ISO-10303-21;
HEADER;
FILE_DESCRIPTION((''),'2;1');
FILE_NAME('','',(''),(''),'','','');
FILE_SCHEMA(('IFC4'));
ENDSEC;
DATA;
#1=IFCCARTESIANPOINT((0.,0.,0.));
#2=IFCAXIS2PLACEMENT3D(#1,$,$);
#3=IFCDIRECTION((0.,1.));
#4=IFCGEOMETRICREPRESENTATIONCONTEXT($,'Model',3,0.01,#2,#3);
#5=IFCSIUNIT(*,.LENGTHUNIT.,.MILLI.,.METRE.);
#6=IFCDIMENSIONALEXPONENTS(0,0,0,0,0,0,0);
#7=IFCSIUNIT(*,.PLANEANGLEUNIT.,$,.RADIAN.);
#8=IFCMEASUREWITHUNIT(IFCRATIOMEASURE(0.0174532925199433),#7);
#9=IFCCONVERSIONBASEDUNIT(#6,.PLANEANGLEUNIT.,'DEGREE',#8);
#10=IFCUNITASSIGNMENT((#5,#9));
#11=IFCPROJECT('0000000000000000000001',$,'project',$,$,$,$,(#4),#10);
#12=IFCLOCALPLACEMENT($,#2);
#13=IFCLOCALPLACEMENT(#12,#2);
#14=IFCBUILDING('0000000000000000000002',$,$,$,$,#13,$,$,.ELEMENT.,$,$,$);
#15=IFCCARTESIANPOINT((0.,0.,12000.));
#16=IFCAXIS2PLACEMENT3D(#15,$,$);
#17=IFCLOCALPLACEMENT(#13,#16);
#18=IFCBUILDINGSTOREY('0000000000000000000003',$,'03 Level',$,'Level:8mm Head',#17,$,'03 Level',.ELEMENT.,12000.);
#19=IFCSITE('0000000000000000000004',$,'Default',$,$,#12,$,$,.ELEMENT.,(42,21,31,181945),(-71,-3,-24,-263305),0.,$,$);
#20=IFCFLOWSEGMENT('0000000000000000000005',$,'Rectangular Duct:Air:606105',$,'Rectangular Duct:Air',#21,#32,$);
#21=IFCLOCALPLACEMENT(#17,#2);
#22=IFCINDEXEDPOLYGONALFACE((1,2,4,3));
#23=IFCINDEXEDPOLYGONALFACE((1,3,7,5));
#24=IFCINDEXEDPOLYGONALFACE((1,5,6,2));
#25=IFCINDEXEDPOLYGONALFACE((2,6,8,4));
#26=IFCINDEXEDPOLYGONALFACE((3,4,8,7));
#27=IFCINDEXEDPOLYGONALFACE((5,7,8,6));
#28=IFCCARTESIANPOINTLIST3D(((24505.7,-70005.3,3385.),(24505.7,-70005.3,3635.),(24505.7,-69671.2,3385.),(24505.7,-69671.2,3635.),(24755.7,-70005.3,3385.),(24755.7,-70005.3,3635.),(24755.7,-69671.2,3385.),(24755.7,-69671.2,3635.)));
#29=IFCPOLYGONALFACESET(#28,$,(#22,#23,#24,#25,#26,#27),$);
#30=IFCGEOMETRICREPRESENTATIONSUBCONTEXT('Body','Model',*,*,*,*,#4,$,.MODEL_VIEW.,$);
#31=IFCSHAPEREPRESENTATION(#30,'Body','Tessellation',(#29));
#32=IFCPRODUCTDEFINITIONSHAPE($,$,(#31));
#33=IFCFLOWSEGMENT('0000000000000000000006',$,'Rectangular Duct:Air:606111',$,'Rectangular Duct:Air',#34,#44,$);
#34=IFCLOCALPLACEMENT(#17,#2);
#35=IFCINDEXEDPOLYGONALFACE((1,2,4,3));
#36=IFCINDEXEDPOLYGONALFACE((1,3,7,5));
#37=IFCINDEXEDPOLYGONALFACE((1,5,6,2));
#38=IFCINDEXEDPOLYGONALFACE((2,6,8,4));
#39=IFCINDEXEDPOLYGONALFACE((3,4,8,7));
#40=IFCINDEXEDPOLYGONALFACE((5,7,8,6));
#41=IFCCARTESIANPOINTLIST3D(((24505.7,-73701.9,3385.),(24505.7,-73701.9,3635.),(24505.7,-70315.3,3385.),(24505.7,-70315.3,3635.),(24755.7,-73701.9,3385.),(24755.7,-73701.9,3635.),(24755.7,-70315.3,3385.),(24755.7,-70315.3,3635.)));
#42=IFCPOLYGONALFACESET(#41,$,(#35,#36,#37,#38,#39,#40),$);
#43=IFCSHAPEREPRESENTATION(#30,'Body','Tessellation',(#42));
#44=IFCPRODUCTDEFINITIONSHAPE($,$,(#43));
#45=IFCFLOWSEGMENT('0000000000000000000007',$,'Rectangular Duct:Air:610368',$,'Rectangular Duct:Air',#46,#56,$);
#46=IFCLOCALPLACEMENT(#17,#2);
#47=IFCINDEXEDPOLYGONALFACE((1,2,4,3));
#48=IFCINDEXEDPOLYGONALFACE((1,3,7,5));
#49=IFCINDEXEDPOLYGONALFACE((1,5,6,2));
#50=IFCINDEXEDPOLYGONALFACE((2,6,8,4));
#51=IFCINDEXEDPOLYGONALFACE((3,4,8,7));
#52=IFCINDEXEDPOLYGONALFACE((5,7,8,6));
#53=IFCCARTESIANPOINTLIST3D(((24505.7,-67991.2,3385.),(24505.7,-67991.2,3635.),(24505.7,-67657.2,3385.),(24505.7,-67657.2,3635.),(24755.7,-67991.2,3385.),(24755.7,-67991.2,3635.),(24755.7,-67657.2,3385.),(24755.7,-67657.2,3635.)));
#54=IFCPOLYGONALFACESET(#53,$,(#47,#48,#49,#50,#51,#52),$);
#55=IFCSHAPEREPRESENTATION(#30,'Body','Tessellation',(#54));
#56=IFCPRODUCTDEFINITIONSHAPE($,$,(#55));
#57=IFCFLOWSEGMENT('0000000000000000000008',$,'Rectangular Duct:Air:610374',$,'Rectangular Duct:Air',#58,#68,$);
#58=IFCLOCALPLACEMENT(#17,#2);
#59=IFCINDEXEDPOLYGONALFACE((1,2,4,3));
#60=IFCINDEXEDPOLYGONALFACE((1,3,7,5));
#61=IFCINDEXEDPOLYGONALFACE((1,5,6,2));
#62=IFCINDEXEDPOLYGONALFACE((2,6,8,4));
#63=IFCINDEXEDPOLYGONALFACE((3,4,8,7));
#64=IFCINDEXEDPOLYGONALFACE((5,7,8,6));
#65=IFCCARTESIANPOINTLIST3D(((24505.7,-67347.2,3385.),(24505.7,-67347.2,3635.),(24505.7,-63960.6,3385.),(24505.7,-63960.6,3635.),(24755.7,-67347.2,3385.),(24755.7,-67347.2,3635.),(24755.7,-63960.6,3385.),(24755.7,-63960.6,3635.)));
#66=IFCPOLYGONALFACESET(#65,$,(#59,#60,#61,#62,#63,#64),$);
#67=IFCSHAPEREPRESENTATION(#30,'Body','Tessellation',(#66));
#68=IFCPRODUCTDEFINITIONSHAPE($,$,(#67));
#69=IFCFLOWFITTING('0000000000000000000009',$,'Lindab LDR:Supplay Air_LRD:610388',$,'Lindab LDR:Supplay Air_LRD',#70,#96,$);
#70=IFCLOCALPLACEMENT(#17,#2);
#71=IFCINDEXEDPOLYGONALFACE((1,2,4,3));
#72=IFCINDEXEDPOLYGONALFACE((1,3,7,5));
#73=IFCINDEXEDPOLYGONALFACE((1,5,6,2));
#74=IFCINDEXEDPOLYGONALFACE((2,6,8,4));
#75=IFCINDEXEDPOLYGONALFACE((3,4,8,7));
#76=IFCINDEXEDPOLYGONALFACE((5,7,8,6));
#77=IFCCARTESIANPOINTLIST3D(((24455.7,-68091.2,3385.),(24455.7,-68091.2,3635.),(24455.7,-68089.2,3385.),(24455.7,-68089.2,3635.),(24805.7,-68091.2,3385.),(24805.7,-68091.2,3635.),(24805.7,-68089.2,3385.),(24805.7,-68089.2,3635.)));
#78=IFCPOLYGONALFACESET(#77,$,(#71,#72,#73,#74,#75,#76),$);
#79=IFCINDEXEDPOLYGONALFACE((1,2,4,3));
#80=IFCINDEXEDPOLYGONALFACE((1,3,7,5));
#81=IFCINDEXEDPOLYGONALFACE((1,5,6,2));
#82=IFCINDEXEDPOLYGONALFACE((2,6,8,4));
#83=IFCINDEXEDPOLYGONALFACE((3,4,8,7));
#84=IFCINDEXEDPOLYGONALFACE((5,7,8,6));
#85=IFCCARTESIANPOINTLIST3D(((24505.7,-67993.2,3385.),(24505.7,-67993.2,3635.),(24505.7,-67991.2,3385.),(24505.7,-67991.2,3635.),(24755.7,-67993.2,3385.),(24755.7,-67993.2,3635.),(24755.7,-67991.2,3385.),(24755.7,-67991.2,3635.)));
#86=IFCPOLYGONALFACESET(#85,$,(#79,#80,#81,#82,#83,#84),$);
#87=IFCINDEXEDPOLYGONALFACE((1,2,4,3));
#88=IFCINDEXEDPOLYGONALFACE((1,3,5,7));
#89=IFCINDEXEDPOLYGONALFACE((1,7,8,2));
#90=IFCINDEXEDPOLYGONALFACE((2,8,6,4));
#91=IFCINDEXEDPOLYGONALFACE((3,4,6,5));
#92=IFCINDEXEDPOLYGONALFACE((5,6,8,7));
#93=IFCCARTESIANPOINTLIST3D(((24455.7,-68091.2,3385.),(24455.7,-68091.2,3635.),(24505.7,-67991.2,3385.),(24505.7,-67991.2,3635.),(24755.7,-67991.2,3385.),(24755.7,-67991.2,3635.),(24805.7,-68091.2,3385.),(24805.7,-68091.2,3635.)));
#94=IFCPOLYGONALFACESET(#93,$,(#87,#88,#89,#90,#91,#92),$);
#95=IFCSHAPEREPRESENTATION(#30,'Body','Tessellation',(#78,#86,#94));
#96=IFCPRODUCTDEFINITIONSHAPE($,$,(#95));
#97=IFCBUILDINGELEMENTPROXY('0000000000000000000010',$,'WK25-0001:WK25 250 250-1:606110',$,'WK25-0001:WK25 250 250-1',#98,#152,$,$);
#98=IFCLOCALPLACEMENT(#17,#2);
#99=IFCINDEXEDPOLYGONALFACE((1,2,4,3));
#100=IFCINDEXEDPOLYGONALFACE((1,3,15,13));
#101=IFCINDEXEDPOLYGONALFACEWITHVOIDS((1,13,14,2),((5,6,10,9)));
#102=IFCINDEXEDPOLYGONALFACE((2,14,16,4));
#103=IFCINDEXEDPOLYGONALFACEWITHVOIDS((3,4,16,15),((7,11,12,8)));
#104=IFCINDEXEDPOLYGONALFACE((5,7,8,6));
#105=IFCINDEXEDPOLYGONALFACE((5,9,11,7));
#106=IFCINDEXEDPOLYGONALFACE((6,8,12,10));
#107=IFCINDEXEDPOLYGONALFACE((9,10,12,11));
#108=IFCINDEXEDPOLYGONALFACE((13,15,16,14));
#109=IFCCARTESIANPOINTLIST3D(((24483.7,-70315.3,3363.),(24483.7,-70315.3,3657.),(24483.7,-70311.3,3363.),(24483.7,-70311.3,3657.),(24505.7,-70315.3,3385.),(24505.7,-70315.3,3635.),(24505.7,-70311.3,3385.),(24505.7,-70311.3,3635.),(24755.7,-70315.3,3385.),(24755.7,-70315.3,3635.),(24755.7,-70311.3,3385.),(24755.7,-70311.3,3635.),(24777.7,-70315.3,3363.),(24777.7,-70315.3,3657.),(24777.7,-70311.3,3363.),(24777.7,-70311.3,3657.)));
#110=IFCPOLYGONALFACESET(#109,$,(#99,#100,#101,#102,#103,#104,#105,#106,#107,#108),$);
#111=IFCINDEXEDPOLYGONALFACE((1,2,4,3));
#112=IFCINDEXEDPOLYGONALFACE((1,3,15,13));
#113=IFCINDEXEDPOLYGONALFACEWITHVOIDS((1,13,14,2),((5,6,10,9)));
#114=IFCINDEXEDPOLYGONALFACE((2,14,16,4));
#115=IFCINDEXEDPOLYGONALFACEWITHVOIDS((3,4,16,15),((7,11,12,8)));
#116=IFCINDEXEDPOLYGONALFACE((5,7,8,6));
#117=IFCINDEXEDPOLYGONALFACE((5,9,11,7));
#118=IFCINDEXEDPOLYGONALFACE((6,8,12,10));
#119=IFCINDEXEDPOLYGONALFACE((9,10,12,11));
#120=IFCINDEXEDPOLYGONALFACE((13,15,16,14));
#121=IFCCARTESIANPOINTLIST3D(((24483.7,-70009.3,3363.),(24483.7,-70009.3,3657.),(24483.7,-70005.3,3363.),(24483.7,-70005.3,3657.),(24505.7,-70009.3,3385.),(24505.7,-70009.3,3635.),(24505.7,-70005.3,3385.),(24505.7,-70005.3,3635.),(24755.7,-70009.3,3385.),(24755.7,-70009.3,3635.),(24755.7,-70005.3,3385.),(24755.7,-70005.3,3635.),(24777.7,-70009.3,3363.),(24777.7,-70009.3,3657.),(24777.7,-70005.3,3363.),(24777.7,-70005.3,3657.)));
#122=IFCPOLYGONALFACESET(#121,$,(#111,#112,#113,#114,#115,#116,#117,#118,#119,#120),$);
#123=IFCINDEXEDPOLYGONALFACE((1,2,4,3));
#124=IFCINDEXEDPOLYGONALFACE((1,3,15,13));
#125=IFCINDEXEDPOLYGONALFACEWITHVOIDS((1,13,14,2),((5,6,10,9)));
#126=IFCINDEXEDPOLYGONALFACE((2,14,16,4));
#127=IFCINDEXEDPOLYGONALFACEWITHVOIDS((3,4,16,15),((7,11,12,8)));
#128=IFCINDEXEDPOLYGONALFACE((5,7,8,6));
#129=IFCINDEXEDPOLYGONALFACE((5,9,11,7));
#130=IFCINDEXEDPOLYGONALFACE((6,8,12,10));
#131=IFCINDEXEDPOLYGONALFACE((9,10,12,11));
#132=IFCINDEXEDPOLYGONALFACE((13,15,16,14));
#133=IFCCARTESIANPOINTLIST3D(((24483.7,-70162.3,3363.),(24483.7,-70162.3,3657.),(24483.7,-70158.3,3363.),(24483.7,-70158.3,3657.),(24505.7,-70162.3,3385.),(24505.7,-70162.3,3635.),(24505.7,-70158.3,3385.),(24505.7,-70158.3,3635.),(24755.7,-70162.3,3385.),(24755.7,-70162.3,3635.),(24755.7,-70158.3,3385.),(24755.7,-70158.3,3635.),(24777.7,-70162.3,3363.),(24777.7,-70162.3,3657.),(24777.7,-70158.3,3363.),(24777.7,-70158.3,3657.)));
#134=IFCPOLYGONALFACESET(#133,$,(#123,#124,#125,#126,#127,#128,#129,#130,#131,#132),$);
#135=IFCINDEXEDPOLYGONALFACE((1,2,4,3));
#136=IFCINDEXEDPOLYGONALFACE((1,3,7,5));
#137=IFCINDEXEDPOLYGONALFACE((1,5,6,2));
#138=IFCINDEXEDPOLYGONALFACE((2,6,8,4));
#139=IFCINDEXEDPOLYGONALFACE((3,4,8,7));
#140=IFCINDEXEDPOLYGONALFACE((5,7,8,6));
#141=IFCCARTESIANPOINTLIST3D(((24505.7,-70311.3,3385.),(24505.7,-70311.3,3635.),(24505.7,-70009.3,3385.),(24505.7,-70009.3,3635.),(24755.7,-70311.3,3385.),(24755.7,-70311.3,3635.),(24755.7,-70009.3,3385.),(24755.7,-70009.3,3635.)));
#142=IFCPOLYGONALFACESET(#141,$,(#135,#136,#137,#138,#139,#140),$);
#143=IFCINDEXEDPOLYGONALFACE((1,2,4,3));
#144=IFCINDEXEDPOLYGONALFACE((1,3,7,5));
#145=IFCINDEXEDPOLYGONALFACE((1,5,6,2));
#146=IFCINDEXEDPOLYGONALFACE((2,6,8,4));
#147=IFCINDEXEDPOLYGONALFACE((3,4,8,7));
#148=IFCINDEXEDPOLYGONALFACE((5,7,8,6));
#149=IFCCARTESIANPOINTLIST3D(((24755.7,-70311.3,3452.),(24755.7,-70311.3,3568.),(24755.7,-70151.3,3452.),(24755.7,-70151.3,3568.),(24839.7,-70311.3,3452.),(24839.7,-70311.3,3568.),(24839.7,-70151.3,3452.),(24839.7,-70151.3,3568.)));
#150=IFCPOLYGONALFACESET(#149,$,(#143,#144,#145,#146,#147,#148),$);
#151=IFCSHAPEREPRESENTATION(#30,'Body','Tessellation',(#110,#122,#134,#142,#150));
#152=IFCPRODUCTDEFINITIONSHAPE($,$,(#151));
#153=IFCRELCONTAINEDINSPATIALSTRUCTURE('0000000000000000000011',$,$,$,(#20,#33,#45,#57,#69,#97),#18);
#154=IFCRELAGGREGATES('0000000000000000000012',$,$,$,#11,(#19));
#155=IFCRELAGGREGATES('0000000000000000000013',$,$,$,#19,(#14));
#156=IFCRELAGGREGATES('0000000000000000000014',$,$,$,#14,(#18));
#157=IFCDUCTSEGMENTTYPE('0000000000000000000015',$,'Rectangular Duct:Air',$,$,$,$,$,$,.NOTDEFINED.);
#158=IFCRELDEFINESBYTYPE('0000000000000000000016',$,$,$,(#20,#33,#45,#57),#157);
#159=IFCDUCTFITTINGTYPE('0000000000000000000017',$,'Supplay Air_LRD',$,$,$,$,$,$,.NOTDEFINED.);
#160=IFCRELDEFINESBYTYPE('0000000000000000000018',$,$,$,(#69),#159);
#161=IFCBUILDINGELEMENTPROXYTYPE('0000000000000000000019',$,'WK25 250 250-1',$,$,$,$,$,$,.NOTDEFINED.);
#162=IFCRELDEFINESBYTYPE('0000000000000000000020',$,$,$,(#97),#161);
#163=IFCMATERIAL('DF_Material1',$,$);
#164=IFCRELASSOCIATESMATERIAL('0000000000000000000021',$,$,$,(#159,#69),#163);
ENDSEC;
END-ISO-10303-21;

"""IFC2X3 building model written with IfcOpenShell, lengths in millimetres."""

from ifc_helpers import new_model, entity, si_unit, converted_unit, direction, frame, frame_2d, origin, origin_2d_with_axis, place, context, subcontext, project, spatial, polyline, rectangle, outline, extrude, source, transform, mapped, material, type_object, type_shapes, element, save


model = new_model("IFC2X3")

# Units and contexts
model_context = context("Model", 3, precision=0.01, world=origin(), true_north=direction((0.0, 1.0)))
body_context = subcontext(model_context, "Body", "Model", "MODEL_VIEW")
ifc_project = project(units=[si_unit("LENGTHUNIT", "METRE", prefix="MILLI"), converted_unit("PLANEANGLEUNIT", "DEGREE", entity("IfcRatioMeasure", 0.0174532925199433), si_unit("PLANEANGLEUNIT", "RADIAN"), dimensions=[0, 0, 0, 0, 0, 0, 0])], contexts=[model_context])

# Site, building, storey
site_placement = place(None, origin())
site = spatial("IfcSite", under=ifc_project, at=site_placement, Name="Default", CompositionType="ELEMENT", RefLatitude=(42, 21, 31, 181945), RefLongitude=(-71, -3, -24, -263305), RefElevation=0.0)
building_placement = place(site_placement, origin())
building = spatial("IfcBuilding", under=site, at=building_placement, CompositionType="ELEMENT")
storey_placement = place(building_placement, frame((0.0, 0.0, 12000.0)))
storey = spatial("IfcBuildingStorey", under=building, at=storey_placement, Name="03 Level", ObjectType="Level:8mm Head", LongName="03 Level", CompositionType="ELEMENT", Elevation=12000.0)

# Flow segments
duct_segment_type_1 = type_object("IfcDuctSegmentType", Name="Rectangular Duct:Air", PredefinedType="NOTDEFINED")
flow_segment_1_placement = place(storey_placement, frame((24505.7, -70005.3, 3385.0)))
element("IfcFlowSegment", 1, at=flow_segment_1_placement, inside=storey, type_object=duct_segment_type_1, Name="Rectangular Duct:Air:606105", ObjectType="Rectangular Duct:Air", context=body_context, shape_type="SweptSolid", body=[
    extrude(rectangle(XDim=334.0, YDim=250.0, at=frame_2d((0.0, 0.0), x_axis=(1.0, 0.0))), frame((125.0, 167.0, 0.0), z_axis=(0.0, 0.0, 1.0), x_axis=(0.0, 1.0, 0.0)), (0.0, 0.0, 1.0), 250.0),
])
flow_segment_2_placement = place(storey_placement, frame((24505.7, -73701.9, 3385.0)))
element("IfcFlowSegment", 2, at=flow_segment_2_placement, inside=storey, type_object=duct_segment_type_1, Name="Rectangular Duct:Air:606111", ObjectType="Rectangular Duct:Air", context=body_context, shape_type="SweptSolid", body=[
    extrude(rectangle(XDim=3386.6, YDim=250.0, at=frame_2d((0.0, 0.0), x_axis=(1.0, 0.0))), frame((125.0, 1693.3, 0.0), z_axis=(0.0, 0.0, 1.0), x_axis=(0.0, 1.0, 0.0)), (0.0, 0.0, 1.0), 250.0),
])
flow_segment_3_placement = place(storey_placement, frame((24505.7, -67991.2, 3385.0)))
element("IfcFlowSegment", 3, at=flow_segment_3_placement, inside=storey, type_object=duct_segment_type_1, Name="Rectangular Duct:Air:610368", ObjectType="Rectangular Duct:Air", context=body_context, shape_type="SweptSolid", body=[
    extrude(rectangle(XDim=334.0, YDim=250.0, at=frame_2d((0.0, 0.0), x_axis=(1.0, 0.0))), frame((125.0, 167.0, 0.0), z_axis=(0.0, 0.0, 1.0), x_axis=(0.0, -1.0, 0.0)), (0.0, 0.0, 1.0), 250.0),
])
flow_segment_4_placement = place(storey_placement, frame((24505.7, -67347.2, 3385.0)))
element("IfcFlowSegment", 4, at=flow_segment_4_placement, inside=storey, type_object=duct_segment_type_1, Name="Rectangular Duct:Air:610374", ObjectType="Rectangular Duct:Air", context=body_context, shape_type="SweptSolid", body=[
    extrude(rectangle(XDim=3386.6, YDim=250.0, at=frame_2d((0.0, 0.0), x_axis=(1.0, 0.0))), frame((125.0, 1693.3, 0.0), z_axis=(0.0, 0.0, 1.0), x_axis=(0.0, -1.0, 0.0)), (0.0, 0.0, 1.0), 250.0),
])

# Flow fitting
ifc_material = material(Name="DF_Material1")
duct_fitting_type_1 = type_object("IfcDuctFittingType", Name="Supplay Air_LRD", PredefinedType="NOTDEFINED", material=ifc_material)
shared_shape_1 = source(origin(), body_context, "Body", "SweptSolid", [
    extrude(rectangle(XDim=350.0, YDim=2.0, at=origin_2d_with_axis()), frame((99.0, 0.0, -125.0), z_axis=(0.0, 0.0, 1.0), x_axis=(0.0, 1.0, 0.0)), (0.0, 0.0, 1.0), 250.0),
    extrude(rectangle(XDim=250.0, YDim=2.0, at=origin_2d_with_axis()), frame((1.0, 0.0, -125.0), z_axis=(0.0, 0.0, 1.0), x_axis=(0.0, 1.0, 0.0)), (0.0, 0.0, 1.0), 250.0),
    extrude(outline(polyline([(-125.0, -50.0), (125.0, -50.0), (175.0, 50.0), (-175.0, 50.0), (-125.0, -50.0)])), frame((50.0, 0.0, -125.0), z_axis=(0.0, 0.0, 1.0), x_axis=(0.0, -1.0, 0.0)), (0.0, 0.0, 1.0), 250.0),
])
type_shapes(duct_fitting_type_1, [shared_shape_1])
flow_fitting_1_placement = place(storey_placement, frame((24630.7, -67991.2, 3510.0), z_axis=(0.0, 0.0, 1.0), x_axis=(0.0, -1.0, 0.0)))
element("IfcFlowFitting", 5, at=flow_fitting_1_placement, inside=storey, type_object=duct_fitting_type_1, material=ifc_material, Name="Lindab LDR:Supplay Air_LRD:610388", ObjectType="Lindab LDR:Supplay Air_LRD", context=body_context, shape_type="MappedRepresentation", body=[
    mapped(shared_shape_1, transform((0.0, 0.0, 0.0), scale=1.0)),
])

# Building element proxy
building_element_proxy_type_1 = type_object("IfcBuildingElementProxyType", Name="WK25 250 250-1", PredefinedType="NOTDEFINED")
shared_shape_2 = source(origin(), body_context, "Body", "SweptSolid", [
    extrude(outline(polyline([(-147.0, -147.0), (147.0, -147.0), (147.0, 147.0), (-147.0, 147.0), (-147.0, -147.0)]), holes=[polyline([(-125.0, -125.0), (-125.0, 125.0), (125.0, 125.0), (125.0, -125.0), (-125.0, -125.0)])]), frame((151.0, 0.0, 0.0), z_axis=(1.0, 0.0, 0.0), x_axis=(0.0, 0.0, -1.0)), (0.0, 0.0, 1.0), 4.0),
    extrude(outline(polyline([(-147.0, -147.0), (147.0, -147.0), (147.0, 147.0), (-147.0, 147.0), (-147.0, -147.0)]), holes=[polyline([(-125.0, -125.0), (-125.0, 125.0), (125.0, 125.0), (125.0, -125.0), (-125.0, -125.0)])]), frame((-155.0, 0.0, 0.0), z_axis=(1.0, 0.0, 0.0), x_axis=(0.0, -1.0, 0.0)), (0.0, 0.0, 1.0), 4.0),
    extrude(outline(polyline([(-147.0, -147.0), (147.0, -147.0), (147.0, 147.0), (-147.0, 147.0), (-147.0, -147.0)]), holes=[polyline([(-125.0, -125.0), (-125.0, 125.0), (125.0, 125.0), (125.0, -125.0), (-125.0, -125.0)])]), frame((-2.0, 0.0, 0.0), z_axis=(1.0, 0.0, 0.0), x_axis=(0.0, -1.0, 0.0)), (0.0, 0.0, 1.0), 4.0),
    extrude(rectangle(XDim=302.0, YDim=250.0, at=origin_2d_with_axis()), frame((0.0, 0.0, -125.0), z_axis=(0.0, 0.0, 1.0), x_axis=(-1.0, 0.0, 0.0)), (0.0, 0.0, 1.0), 250.0),
    extrude(rectangle(XDim=84.0, YDim=160.0, at=frame_2d((0.0, 0.0), x_axis=(1.0, 0.0))), frame((71.0, -167.0, -58.0), z_axis=(0.0, 0.0, 1.0), x_axis=(0.0, -1.0, 0.0)), (0.0, 0.0, 1.0), 116.0),
])
type_shapes(building_element_proxy_type_1, [shared_shape_2])
proxy_1_placement = place(storey_placement, frame((24630.7, -70160.3, 3510.0), z_axis=(0.0, 0.0, -1.0), x_axis=(0.0, -1.0, 0.0)))
element("IfcBuildingElementProxy", 6, at=proxy_1_placement, inside=storey, type_object=building_element_proxy_type_1, Name="WK25-0001:WK25 250 250-1:606110", ObjectType="WK25-0001:WK25 250 250-1", context=body_context, shape_type="MappedRepresentation", body=[
    mapped(shared_shape_2, transform((0.0, 0.0, 0.0), scale=1.0)),
])

save(model, "model.ifc")
